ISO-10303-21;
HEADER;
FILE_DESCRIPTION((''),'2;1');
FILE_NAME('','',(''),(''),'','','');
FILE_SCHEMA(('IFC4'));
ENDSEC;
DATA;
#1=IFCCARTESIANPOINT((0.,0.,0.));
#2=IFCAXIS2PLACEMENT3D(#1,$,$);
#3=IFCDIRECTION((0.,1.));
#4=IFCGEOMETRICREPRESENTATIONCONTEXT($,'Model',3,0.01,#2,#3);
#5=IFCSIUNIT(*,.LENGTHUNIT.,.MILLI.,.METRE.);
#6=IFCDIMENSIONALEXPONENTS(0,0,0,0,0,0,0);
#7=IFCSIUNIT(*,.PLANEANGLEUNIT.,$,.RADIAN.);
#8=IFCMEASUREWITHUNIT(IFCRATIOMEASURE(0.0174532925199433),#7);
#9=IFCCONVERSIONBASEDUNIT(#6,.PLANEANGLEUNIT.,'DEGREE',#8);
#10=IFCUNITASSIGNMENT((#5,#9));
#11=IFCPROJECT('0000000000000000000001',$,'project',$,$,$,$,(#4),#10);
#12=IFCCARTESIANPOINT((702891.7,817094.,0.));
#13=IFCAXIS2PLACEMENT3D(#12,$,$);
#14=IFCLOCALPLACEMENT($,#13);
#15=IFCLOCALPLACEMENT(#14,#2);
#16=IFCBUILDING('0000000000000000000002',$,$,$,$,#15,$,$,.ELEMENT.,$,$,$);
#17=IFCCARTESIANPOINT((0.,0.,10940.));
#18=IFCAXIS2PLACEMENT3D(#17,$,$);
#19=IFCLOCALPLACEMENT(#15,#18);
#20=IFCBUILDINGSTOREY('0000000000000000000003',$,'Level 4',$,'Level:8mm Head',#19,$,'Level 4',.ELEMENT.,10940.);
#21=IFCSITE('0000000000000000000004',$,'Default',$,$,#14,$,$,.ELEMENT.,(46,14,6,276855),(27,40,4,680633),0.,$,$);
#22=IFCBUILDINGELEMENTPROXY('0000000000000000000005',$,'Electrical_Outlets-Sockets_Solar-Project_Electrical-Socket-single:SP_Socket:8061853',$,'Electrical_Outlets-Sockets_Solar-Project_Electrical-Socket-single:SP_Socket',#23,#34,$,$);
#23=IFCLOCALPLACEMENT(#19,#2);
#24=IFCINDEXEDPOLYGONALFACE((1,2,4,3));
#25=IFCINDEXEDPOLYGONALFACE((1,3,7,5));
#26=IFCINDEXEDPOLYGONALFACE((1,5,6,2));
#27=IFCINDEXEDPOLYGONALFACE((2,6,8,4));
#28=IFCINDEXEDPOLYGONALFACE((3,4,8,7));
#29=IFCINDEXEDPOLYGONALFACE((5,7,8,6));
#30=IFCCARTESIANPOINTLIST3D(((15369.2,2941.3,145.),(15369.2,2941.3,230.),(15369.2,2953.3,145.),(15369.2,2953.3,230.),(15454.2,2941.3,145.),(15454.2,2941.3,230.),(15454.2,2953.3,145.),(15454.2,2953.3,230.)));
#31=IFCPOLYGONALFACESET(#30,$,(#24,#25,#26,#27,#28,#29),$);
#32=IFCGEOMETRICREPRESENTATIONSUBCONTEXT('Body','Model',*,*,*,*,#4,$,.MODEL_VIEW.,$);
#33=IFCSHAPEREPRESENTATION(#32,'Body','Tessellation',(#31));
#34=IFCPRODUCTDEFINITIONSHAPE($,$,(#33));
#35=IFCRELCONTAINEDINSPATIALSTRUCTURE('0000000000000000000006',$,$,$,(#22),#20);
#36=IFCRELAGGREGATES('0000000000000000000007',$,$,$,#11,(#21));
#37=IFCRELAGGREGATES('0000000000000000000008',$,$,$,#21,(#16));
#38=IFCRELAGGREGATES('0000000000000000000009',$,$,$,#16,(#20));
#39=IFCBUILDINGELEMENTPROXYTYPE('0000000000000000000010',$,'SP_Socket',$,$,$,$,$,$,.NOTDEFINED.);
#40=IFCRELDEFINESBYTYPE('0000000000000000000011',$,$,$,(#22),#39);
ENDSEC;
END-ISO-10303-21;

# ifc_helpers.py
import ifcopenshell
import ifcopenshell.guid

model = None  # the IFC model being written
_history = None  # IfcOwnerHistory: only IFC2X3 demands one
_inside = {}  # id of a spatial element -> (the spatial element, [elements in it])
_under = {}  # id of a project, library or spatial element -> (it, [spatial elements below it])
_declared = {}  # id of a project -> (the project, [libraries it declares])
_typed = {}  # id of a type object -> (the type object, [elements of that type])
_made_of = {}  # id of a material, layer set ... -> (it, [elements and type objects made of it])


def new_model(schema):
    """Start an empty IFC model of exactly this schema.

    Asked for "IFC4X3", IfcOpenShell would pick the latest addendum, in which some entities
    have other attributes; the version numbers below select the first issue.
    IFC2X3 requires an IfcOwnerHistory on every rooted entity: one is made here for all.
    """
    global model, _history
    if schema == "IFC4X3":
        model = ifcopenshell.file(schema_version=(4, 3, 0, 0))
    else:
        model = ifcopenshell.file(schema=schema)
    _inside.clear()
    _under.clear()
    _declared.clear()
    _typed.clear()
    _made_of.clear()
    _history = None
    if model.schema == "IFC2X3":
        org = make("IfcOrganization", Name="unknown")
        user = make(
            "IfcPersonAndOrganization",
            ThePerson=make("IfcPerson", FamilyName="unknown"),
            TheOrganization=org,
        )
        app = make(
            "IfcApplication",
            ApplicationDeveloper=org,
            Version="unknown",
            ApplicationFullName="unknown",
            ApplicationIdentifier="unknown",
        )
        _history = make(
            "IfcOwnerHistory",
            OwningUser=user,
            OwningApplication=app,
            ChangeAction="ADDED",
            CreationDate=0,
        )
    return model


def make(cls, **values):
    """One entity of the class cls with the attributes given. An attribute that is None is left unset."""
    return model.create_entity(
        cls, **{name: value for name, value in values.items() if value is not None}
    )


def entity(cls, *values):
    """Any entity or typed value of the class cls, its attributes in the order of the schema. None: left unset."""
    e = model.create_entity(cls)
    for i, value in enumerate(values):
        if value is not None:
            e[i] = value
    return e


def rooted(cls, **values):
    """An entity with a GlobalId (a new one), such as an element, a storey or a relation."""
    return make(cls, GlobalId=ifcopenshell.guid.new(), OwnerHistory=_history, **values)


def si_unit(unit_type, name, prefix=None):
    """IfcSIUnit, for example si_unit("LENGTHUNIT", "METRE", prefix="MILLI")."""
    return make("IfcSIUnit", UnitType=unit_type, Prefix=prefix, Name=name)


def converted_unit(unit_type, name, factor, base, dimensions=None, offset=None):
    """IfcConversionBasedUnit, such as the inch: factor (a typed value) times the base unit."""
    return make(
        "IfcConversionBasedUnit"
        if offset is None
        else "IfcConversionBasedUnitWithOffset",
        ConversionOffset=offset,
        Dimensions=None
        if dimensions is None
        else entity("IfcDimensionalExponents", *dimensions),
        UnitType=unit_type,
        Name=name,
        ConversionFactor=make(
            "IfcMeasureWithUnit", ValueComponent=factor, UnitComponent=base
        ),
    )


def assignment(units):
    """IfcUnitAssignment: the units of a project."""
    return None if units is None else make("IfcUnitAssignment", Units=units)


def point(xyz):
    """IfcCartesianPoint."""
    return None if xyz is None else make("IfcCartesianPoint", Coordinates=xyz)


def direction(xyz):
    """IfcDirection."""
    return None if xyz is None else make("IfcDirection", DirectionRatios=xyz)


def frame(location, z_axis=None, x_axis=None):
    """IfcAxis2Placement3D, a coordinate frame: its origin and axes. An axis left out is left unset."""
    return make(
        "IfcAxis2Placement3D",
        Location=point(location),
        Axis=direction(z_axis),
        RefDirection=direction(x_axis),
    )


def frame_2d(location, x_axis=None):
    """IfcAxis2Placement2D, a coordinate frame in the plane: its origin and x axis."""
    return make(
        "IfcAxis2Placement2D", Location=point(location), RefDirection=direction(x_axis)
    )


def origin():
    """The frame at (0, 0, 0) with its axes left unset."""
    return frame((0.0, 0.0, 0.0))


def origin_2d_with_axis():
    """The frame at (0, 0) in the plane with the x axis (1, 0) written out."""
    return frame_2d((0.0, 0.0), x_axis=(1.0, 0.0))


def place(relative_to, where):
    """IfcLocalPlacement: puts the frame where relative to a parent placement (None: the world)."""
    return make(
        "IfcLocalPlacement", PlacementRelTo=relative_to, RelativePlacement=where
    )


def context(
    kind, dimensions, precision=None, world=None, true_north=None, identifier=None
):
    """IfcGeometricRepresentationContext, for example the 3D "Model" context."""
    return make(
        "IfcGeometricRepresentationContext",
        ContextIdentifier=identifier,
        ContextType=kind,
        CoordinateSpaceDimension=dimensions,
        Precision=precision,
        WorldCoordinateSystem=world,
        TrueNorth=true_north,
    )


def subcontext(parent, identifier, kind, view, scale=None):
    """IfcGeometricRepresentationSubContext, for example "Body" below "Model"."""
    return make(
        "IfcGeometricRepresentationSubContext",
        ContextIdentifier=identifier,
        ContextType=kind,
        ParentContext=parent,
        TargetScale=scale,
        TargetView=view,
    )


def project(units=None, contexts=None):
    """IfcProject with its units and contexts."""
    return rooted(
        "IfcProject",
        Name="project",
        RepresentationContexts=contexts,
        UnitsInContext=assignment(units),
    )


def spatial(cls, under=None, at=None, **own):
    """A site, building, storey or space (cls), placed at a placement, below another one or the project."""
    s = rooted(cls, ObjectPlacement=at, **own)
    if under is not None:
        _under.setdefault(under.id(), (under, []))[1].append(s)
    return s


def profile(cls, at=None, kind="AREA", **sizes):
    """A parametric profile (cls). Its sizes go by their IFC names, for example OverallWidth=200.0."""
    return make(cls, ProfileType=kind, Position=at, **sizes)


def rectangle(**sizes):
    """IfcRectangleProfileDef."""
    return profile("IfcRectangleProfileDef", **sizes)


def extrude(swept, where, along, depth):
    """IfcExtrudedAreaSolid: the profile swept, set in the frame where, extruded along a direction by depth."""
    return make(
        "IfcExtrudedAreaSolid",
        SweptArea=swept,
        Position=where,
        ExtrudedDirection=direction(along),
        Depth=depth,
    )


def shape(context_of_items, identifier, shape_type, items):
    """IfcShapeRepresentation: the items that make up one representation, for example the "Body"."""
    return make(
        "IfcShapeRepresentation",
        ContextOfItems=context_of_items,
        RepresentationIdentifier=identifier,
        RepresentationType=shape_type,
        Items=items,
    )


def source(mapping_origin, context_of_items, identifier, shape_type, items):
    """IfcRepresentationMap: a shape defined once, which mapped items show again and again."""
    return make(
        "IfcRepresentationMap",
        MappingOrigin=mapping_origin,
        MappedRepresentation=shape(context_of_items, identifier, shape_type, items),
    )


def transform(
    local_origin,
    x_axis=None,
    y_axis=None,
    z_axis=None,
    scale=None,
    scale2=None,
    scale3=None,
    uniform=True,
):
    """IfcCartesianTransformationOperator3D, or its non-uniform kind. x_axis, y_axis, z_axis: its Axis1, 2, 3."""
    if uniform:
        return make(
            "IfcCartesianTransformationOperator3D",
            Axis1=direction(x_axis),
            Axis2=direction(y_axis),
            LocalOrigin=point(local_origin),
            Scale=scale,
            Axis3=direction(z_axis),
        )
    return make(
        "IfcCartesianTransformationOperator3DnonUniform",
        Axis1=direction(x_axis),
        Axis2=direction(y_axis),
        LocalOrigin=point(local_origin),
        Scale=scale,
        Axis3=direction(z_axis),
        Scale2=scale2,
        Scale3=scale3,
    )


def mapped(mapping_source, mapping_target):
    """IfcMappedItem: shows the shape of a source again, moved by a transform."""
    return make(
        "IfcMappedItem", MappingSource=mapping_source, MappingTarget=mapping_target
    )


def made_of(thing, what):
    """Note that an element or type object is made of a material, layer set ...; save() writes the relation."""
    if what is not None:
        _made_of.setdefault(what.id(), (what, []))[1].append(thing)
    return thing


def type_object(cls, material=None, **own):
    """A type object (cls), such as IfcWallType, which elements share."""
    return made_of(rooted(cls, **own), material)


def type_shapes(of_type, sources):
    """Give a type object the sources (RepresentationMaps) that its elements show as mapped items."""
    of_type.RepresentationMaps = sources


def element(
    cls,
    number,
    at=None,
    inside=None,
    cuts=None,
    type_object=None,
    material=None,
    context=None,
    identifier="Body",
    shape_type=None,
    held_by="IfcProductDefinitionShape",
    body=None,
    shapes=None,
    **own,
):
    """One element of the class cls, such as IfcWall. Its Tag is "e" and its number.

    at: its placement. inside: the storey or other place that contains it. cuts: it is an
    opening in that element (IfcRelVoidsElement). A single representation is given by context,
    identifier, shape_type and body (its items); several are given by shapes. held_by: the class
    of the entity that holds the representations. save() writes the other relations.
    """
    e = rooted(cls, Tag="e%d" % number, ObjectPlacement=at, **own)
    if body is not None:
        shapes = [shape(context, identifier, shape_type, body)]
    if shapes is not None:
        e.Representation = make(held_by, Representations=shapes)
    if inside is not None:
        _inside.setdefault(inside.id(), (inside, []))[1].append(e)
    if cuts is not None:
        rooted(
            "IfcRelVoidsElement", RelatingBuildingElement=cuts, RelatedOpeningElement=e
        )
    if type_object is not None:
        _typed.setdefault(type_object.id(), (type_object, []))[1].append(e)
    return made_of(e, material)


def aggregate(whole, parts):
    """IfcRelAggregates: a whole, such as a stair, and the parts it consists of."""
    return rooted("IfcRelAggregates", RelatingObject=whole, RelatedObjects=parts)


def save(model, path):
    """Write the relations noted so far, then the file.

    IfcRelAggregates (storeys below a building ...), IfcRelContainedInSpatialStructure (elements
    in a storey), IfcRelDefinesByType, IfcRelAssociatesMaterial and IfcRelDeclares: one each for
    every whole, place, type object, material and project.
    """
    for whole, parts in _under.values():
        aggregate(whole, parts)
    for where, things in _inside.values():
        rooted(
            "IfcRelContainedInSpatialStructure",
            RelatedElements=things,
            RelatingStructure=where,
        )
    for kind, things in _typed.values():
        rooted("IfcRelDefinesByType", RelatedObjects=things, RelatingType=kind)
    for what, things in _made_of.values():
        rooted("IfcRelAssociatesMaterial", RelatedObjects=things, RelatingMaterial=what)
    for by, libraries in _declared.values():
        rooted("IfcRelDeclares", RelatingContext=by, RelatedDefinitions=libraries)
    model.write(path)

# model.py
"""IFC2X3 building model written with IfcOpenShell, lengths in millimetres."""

from ifc_helpers import new_model, entity, si_unit, converted_unit, direction, frame, origin, origin_2d_with_axis, place, context, subcontext, project, spatial, rectangle, extrude, source, transform, mapped, type_object, type_shapes, element, save


model = new_model("IFC2X3")

# Units and contexts
model_context = context("Model", 3, precision=0.01, world=origin(), true_north=direction((0.0, 1.0)))
body_context = subcontext(model_context, "Body", "Model", "MODEL_VIEW")
ifc_project = project(units=[si_unit("LENGTHUNIT", "METRE", prefix="MILLI"), converted_unit("PLANEANGLEUNIT", "DEGREE", entity("IfcRatioMeasure", 0.0174532925199433), si_unit("PLANEANGLEUNIT", "RADIAN"), dimensions=[0, 0, 0, 0, 0, 0, 0])], contexts=[model_context])

# Site, building, storey
site_placement = place(None, frame((702891.7, 817094.0, 0.0)))
site = spatial("IfcSite", under=ifc_project, at=site_placement, Name="Default", CompositionType="ELEMENT", RefLatitude=(46, 14, 6, 276855), RefLongitude=(27, 40, 4, 680633), RefElevation=0.0)
building_placement = place(site_placement, origin())
building = spatial("IfcBuilding", under=site, at=building_placement, CompositionType="ELEMENT")
storey_placement = place(building_placement, frame((0.0, 0.0, 10940.0)))
storey = spatial("IfcBuildingStorey", under=building, at=storey_placement, Name="Level 4", ObjectType="Level:8mm Head", LongName="Level 4", CompositionType="ELEMENT", Elevation=10940.0)

# Building element proxy
building_element_proxy_type_1 = type_object("IfcBuildingElementProxyType", Name="SP_Socket", PredefinedType="NOTDEFINED")
shared_shape_1 = source(origin(), body_context, "Body", "SweptSolid", [
    extrude(rectangle(XDim=12.0, YDim=85.0, at=origin_2d_with_axis()), frame((0.0, -6.0, -85.0), z_axis=(0.0, 0.0, 1.0), x_axis=(0.0, 1.0, 0.0)), (0.0, 0.0, 1.0), 85.0),
])
type_shapes(building_element_proxy_type_1, [shared_shape_1])
proxy_1_placement = place(storey_placement, frame((15411.7, 2953.3, 230.0)))
element("IfcBuildingElementProxy", 1, at=proxy_1_placement, inside=storey, type_object=building_element_proxy_type_1, Name="Electrical_Outlets-Sockets_Solar-Project_Electrical-Socket-single:SP_Socket:8061853", ObjectType="Electrical_Outlets-Sockets_Solar-Project_Electrical-Socket-single:SP_Socket", context=body_context, shape_type="MappedRepresentation", body=[
    mapped(shared_shape_1, transform((0.0, 0.0, 0.0), scale=1.0)),
])

save(model, "model.ifc")
